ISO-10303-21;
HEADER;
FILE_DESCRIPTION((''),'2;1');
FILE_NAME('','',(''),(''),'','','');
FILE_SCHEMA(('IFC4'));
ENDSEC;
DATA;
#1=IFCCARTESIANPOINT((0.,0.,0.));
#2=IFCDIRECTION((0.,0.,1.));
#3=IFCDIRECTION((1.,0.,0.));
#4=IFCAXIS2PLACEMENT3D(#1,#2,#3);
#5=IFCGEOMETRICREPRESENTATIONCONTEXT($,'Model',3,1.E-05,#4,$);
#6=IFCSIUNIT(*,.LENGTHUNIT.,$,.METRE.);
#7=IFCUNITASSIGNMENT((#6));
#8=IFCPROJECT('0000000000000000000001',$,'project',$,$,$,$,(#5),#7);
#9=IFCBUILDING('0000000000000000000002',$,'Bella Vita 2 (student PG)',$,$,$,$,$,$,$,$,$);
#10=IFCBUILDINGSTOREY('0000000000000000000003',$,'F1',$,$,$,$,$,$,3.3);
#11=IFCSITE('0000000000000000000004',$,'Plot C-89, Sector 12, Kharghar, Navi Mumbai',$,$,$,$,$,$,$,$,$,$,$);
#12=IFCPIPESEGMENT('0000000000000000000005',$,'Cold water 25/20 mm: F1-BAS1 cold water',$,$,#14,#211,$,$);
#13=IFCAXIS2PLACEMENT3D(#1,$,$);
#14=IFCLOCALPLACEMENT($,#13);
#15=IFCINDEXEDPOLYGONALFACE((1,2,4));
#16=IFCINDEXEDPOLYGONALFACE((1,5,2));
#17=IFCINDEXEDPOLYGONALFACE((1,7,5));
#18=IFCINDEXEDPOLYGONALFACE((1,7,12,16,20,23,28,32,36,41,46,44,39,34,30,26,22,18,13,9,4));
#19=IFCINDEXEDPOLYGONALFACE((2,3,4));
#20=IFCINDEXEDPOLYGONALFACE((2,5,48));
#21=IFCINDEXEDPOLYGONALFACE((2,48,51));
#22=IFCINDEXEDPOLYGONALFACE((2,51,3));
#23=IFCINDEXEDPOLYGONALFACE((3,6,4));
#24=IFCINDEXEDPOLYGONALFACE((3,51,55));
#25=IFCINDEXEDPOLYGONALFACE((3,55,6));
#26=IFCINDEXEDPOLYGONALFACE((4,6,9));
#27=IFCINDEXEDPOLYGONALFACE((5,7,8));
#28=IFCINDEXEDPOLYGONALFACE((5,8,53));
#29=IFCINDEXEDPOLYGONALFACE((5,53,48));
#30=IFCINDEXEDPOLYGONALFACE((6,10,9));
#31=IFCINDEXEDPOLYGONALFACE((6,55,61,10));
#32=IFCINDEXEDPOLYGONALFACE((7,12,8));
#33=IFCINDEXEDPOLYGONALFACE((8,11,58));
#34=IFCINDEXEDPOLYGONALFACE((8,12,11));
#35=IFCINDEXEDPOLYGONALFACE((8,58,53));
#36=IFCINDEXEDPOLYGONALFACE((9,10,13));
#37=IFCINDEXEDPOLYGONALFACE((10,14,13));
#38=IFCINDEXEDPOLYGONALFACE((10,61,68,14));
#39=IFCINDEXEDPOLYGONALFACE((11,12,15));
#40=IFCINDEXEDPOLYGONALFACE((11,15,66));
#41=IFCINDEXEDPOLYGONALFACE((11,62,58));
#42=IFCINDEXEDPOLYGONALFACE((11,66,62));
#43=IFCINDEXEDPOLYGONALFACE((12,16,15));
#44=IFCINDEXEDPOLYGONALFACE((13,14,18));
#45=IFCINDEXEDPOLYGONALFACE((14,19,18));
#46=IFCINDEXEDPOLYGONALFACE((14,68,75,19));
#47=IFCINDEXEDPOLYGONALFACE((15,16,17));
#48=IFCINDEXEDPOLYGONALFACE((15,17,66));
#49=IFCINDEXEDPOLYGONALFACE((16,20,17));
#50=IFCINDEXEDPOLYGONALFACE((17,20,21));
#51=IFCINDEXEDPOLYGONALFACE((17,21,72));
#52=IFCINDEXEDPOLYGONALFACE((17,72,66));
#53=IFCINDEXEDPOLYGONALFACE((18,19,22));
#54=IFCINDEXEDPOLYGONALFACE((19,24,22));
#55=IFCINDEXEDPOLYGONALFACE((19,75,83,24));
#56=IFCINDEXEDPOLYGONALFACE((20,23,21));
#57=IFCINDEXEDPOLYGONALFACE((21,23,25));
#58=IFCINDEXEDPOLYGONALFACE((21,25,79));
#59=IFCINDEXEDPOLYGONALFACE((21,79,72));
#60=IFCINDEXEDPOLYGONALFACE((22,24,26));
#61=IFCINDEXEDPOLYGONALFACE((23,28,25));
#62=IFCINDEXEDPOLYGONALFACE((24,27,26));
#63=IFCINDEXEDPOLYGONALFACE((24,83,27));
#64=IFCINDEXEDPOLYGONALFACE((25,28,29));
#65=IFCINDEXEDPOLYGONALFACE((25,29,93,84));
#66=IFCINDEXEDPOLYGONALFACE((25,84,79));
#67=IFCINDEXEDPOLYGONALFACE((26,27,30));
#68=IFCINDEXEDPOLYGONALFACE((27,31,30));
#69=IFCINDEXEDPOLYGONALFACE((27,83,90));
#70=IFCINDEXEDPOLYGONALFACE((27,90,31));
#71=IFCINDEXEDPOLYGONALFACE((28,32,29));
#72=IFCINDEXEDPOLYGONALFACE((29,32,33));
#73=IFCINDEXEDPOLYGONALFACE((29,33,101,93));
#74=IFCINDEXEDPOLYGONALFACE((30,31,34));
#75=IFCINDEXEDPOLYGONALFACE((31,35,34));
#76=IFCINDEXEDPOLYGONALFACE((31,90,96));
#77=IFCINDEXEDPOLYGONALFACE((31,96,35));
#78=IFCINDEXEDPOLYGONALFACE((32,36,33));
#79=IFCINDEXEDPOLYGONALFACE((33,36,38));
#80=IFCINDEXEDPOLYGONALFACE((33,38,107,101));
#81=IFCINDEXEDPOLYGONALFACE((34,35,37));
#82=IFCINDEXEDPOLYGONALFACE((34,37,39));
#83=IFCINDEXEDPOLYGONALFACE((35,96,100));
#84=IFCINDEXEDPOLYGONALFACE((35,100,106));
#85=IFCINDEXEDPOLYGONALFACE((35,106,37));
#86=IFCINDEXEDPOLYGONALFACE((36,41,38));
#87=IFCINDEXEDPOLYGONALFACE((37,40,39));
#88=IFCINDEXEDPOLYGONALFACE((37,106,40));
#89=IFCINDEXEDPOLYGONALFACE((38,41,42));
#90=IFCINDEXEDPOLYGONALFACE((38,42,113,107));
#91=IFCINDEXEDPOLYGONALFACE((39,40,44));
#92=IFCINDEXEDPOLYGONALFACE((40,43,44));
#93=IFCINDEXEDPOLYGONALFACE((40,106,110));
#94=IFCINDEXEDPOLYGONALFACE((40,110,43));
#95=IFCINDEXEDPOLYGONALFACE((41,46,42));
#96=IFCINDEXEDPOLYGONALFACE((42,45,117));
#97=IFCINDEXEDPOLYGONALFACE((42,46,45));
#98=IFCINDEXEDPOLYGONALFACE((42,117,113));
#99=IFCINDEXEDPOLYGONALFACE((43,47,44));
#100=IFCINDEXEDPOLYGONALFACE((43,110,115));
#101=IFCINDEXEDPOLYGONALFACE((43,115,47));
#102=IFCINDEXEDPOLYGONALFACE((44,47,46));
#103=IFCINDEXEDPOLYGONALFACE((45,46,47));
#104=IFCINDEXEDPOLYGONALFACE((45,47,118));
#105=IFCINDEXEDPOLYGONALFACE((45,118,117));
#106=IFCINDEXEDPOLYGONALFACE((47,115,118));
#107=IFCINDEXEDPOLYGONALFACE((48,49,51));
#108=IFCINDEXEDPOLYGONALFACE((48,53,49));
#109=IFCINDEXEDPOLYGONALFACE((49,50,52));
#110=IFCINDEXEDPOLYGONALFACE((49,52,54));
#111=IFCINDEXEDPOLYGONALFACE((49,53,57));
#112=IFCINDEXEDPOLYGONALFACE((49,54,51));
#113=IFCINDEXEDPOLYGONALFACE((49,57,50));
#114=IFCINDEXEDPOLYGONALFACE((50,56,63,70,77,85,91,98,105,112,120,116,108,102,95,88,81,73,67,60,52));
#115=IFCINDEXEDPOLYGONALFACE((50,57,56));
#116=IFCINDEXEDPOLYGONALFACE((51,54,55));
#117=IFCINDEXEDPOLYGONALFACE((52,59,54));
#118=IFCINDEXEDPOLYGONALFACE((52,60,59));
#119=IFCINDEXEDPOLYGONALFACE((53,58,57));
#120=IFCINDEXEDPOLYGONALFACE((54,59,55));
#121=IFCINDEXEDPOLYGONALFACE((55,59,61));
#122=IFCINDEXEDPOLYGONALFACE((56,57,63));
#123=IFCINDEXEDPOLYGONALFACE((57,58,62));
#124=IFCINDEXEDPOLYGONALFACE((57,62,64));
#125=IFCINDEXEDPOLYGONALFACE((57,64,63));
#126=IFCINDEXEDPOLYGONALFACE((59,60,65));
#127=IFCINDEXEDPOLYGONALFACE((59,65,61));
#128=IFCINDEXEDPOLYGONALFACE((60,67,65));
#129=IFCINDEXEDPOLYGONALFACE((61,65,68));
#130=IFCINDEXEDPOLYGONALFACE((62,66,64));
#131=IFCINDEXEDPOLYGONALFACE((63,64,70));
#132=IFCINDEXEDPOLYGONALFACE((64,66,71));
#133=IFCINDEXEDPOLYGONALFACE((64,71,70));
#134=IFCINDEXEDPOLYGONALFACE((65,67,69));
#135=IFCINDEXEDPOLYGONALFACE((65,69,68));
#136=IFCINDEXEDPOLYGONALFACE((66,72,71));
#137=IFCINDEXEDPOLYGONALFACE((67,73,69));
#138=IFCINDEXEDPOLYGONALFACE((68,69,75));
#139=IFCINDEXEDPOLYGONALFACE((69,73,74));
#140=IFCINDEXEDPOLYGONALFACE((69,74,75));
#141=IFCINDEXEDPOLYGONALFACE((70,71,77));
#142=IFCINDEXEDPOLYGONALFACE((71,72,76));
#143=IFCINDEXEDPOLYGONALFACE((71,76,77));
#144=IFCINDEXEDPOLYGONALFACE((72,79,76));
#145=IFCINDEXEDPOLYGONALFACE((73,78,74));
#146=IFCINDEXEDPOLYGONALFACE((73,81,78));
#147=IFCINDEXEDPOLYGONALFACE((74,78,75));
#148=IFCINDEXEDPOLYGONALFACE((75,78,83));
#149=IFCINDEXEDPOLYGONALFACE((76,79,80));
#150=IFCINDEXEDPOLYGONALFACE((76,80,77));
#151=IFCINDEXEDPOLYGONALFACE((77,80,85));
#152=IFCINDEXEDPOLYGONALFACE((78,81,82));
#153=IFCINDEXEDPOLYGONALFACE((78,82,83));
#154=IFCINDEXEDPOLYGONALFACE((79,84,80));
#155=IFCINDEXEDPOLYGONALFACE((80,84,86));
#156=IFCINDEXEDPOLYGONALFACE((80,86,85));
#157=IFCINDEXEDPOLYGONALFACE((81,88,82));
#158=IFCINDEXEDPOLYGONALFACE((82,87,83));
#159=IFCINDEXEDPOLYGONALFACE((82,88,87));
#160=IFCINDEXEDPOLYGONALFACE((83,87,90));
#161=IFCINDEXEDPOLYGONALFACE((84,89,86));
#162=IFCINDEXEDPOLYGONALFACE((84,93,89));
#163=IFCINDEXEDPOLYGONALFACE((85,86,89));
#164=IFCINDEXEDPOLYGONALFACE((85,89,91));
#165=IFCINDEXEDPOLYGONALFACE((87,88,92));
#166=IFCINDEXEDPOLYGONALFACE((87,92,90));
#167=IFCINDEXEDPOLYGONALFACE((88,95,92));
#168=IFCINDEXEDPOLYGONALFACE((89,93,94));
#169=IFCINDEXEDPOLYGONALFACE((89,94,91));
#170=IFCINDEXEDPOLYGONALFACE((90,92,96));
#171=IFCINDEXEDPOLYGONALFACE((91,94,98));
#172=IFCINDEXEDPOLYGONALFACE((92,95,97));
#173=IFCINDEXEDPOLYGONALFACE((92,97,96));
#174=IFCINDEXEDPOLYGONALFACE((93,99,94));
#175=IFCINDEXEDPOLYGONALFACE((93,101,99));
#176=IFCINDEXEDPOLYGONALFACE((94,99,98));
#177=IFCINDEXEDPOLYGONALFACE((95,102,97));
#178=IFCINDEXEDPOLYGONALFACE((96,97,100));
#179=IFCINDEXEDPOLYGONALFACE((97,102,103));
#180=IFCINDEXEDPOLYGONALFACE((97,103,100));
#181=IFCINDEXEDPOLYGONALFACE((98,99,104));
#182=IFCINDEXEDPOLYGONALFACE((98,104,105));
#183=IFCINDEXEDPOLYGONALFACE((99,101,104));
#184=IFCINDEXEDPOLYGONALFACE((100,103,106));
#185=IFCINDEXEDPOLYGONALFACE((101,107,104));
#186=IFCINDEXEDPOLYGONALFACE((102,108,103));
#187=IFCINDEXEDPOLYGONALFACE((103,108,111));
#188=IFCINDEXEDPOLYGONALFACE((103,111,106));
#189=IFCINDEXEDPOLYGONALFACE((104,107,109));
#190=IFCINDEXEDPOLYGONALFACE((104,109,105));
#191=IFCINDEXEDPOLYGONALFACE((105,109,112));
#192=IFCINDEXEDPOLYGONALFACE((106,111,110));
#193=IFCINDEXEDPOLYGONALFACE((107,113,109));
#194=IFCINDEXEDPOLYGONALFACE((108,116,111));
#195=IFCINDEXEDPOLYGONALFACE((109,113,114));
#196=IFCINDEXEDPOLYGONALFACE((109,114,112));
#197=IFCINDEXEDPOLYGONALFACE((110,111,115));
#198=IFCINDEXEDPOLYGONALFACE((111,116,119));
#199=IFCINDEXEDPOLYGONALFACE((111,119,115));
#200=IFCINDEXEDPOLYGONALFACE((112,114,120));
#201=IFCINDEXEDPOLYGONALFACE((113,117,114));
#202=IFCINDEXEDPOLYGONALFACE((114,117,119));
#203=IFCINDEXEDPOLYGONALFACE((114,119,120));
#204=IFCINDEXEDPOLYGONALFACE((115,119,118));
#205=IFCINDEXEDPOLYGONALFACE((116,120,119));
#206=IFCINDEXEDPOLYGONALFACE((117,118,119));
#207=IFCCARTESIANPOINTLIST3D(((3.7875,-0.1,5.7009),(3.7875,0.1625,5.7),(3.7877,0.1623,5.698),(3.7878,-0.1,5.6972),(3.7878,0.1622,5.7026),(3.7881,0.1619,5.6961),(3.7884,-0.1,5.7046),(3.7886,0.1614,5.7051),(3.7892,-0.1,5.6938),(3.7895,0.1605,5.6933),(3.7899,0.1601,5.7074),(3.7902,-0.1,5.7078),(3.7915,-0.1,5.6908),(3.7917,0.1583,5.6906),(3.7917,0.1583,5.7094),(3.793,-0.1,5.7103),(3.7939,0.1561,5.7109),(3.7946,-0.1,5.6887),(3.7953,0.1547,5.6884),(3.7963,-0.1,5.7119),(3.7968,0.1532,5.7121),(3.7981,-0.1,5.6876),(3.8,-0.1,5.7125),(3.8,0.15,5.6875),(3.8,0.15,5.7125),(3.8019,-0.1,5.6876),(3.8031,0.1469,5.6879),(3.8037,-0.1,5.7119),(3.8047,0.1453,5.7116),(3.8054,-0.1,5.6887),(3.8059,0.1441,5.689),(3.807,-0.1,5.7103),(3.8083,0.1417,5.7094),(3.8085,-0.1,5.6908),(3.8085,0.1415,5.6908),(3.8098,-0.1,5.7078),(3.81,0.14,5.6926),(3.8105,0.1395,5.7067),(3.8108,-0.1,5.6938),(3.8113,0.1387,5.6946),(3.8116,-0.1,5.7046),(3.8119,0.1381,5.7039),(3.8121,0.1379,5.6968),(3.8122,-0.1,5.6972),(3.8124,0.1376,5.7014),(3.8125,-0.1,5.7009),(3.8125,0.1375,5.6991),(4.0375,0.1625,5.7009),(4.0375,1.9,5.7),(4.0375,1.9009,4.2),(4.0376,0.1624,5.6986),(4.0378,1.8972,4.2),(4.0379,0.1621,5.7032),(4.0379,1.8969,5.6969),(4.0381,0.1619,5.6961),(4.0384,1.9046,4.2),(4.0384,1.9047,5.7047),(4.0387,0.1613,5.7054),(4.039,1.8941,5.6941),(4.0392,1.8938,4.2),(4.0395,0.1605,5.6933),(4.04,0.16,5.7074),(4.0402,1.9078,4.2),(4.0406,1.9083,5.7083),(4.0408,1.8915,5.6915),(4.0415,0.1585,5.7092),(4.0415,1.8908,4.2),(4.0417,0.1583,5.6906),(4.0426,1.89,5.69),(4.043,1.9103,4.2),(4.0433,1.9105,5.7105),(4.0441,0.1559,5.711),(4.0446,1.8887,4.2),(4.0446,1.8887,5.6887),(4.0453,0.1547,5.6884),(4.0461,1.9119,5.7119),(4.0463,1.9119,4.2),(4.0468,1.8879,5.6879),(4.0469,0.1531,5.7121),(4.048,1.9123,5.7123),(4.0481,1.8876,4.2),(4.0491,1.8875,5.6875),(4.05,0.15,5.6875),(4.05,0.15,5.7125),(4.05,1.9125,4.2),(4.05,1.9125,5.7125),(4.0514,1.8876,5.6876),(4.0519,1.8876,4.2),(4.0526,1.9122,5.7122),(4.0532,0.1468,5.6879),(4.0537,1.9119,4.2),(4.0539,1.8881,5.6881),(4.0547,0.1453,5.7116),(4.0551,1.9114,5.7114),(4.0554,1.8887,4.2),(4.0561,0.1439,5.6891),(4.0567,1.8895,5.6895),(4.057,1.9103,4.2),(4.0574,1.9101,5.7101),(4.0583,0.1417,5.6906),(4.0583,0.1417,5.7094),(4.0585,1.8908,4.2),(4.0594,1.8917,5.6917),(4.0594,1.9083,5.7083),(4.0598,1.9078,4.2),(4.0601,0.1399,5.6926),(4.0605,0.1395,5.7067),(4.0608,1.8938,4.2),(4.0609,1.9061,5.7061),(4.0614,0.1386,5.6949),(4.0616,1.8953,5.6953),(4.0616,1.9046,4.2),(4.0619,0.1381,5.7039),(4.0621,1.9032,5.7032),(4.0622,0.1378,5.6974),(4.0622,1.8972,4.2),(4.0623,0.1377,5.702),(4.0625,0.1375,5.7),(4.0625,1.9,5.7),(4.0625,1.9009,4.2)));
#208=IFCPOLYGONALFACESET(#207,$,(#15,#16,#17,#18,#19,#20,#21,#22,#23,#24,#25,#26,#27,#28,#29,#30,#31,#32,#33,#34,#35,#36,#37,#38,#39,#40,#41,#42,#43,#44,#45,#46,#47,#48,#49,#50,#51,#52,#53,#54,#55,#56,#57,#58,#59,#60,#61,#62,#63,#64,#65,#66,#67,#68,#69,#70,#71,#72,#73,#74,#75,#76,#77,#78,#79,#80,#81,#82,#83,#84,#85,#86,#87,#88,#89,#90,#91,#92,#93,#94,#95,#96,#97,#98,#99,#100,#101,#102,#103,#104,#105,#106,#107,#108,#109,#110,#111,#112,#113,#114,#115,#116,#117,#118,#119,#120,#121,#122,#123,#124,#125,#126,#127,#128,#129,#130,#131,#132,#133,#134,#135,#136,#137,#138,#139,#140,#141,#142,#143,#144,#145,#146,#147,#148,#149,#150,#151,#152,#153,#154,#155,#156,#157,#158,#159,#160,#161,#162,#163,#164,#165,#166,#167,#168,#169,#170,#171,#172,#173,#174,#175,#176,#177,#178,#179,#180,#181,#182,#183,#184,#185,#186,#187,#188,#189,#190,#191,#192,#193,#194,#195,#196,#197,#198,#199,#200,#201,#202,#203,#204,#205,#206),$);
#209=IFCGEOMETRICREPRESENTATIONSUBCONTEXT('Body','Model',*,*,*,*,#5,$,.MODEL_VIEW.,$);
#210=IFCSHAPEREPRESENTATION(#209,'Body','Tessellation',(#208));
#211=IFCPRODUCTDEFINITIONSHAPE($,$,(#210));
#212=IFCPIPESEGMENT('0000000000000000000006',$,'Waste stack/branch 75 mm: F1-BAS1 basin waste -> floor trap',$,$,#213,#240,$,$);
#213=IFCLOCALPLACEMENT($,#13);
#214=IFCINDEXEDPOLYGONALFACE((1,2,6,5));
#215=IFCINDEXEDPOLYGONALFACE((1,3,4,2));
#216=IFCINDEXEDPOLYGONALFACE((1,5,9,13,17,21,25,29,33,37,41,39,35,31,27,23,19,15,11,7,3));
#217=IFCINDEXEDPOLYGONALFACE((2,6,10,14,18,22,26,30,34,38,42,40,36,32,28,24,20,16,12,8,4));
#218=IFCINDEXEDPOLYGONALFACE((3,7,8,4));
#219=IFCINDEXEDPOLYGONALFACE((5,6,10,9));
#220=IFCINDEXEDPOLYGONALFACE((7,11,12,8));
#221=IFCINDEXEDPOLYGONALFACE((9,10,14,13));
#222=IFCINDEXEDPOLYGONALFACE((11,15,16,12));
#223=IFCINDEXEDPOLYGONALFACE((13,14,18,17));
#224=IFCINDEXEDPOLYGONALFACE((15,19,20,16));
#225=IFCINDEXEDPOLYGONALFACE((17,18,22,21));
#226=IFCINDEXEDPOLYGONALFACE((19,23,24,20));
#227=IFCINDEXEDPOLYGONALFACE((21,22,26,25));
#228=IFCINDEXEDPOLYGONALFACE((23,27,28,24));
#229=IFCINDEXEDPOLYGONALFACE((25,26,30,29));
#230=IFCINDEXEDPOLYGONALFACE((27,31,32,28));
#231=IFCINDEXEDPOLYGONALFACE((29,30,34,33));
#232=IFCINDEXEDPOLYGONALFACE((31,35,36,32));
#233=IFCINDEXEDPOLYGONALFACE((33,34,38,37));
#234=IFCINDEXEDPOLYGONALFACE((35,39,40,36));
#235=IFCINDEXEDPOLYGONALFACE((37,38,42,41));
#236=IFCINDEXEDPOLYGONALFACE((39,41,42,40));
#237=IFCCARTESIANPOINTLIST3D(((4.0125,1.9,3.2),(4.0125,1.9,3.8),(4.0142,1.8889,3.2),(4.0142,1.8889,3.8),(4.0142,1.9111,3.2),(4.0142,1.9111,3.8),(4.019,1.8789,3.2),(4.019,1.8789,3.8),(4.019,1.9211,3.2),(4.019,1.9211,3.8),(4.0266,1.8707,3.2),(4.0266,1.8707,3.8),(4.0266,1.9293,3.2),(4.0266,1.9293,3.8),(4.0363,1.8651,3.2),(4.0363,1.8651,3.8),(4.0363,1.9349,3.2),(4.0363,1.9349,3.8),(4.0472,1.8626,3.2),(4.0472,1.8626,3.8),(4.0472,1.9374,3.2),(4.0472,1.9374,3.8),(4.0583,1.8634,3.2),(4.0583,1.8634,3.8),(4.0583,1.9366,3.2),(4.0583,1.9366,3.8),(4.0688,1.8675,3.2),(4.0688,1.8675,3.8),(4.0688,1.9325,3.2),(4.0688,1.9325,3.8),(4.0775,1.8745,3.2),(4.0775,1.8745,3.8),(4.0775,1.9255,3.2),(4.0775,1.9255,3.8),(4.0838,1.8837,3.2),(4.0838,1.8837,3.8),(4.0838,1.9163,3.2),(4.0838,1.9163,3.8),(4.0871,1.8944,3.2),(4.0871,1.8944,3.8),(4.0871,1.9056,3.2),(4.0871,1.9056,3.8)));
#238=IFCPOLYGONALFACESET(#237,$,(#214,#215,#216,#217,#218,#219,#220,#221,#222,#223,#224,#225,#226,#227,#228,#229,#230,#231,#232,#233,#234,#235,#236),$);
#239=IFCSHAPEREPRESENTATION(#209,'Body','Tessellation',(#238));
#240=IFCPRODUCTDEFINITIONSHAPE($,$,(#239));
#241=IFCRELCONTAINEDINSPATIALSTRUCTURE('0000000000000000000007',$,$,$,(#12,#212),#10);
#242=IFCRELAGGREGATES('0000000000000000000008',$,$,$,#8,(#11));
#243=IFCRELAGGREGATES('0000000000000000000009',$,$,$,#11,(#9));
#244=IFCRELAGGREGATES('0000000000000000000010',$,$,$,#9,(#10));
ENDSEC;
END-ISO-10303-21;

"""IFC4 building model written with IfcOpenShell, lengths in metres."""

from ifc_helpers import new_model, entity, si_unit, origin, origin_with_axes, place, context, subcontext, project, spatial, element, save


model = new_model("IFC4")

# Units and contexts
model_context = context("Model", 3, precision=1e-05, world=origin_with_axes())
body_context = subcontext(model_context, "Body", "Model", "MODEL_VIEW")
ifc_project = project(units=[si_unit("LENGTHUNIT", "METRE")], contexts=[model_context])

# Site, building, storey
site = spatial("IfcSite", under=ifc_project, Name="Plot C-89, Sector 12, Kharghar, Navi Mumbai")
building = spatial("IfcBuilding", under=site, Name="Bella Vita 2 (student PG)")
storey = spatial("IfcBuildingStorey", under=building, Name="F1", Elevation=3.3)

# Pipe segments
pipe_segment_1_placement = place(None, origin())
element("IfcPipeSegment", 1, at=pipe_segment_1_placement, inside=storey, Name="Cold water 25/20 mm: F1-BAS1 cold water", context=body_context, shape_type="AdvancedSweptSolid", body=[
    entity("IfcSweptDiskSolid", entity("IfcPolyline", [entity("IfcCartesianPoint", [3.8, -0.1, 5.7]), entity("IfcCartesianPoint", [3.8, 0.15, 5.7]), entity("IfcCartesianPoint", [4.05, 0.15, 5.7]), entity("IfcCartesianPoint", [4.05, 1.9, 5.7]), entity("IfcCartesianPoint", [4.05, 1.9, 4.2])]), 0.0125),
])
pipe_segment_2_placement = place(None, origin())
element("IfcPipeSegment", 2, at=pipe_segment_2_placement, inside=storey, Name="Waste stack/branch 75 mm: F1-BAS1 basin waste -> floor trap", context=body_context, shape_type="AdvancedSweptSolid", body=[
    entity("IfcSweptDiskSolid", entity("IfcPolyline", [entity("IfcCartesianPoint", [4.05, 1.9, 3.8]), entity("IfcCartesianPoint", [4.05, 1.9, 3.2])]), 0.0375),
])

save(model, "model.ifc")
